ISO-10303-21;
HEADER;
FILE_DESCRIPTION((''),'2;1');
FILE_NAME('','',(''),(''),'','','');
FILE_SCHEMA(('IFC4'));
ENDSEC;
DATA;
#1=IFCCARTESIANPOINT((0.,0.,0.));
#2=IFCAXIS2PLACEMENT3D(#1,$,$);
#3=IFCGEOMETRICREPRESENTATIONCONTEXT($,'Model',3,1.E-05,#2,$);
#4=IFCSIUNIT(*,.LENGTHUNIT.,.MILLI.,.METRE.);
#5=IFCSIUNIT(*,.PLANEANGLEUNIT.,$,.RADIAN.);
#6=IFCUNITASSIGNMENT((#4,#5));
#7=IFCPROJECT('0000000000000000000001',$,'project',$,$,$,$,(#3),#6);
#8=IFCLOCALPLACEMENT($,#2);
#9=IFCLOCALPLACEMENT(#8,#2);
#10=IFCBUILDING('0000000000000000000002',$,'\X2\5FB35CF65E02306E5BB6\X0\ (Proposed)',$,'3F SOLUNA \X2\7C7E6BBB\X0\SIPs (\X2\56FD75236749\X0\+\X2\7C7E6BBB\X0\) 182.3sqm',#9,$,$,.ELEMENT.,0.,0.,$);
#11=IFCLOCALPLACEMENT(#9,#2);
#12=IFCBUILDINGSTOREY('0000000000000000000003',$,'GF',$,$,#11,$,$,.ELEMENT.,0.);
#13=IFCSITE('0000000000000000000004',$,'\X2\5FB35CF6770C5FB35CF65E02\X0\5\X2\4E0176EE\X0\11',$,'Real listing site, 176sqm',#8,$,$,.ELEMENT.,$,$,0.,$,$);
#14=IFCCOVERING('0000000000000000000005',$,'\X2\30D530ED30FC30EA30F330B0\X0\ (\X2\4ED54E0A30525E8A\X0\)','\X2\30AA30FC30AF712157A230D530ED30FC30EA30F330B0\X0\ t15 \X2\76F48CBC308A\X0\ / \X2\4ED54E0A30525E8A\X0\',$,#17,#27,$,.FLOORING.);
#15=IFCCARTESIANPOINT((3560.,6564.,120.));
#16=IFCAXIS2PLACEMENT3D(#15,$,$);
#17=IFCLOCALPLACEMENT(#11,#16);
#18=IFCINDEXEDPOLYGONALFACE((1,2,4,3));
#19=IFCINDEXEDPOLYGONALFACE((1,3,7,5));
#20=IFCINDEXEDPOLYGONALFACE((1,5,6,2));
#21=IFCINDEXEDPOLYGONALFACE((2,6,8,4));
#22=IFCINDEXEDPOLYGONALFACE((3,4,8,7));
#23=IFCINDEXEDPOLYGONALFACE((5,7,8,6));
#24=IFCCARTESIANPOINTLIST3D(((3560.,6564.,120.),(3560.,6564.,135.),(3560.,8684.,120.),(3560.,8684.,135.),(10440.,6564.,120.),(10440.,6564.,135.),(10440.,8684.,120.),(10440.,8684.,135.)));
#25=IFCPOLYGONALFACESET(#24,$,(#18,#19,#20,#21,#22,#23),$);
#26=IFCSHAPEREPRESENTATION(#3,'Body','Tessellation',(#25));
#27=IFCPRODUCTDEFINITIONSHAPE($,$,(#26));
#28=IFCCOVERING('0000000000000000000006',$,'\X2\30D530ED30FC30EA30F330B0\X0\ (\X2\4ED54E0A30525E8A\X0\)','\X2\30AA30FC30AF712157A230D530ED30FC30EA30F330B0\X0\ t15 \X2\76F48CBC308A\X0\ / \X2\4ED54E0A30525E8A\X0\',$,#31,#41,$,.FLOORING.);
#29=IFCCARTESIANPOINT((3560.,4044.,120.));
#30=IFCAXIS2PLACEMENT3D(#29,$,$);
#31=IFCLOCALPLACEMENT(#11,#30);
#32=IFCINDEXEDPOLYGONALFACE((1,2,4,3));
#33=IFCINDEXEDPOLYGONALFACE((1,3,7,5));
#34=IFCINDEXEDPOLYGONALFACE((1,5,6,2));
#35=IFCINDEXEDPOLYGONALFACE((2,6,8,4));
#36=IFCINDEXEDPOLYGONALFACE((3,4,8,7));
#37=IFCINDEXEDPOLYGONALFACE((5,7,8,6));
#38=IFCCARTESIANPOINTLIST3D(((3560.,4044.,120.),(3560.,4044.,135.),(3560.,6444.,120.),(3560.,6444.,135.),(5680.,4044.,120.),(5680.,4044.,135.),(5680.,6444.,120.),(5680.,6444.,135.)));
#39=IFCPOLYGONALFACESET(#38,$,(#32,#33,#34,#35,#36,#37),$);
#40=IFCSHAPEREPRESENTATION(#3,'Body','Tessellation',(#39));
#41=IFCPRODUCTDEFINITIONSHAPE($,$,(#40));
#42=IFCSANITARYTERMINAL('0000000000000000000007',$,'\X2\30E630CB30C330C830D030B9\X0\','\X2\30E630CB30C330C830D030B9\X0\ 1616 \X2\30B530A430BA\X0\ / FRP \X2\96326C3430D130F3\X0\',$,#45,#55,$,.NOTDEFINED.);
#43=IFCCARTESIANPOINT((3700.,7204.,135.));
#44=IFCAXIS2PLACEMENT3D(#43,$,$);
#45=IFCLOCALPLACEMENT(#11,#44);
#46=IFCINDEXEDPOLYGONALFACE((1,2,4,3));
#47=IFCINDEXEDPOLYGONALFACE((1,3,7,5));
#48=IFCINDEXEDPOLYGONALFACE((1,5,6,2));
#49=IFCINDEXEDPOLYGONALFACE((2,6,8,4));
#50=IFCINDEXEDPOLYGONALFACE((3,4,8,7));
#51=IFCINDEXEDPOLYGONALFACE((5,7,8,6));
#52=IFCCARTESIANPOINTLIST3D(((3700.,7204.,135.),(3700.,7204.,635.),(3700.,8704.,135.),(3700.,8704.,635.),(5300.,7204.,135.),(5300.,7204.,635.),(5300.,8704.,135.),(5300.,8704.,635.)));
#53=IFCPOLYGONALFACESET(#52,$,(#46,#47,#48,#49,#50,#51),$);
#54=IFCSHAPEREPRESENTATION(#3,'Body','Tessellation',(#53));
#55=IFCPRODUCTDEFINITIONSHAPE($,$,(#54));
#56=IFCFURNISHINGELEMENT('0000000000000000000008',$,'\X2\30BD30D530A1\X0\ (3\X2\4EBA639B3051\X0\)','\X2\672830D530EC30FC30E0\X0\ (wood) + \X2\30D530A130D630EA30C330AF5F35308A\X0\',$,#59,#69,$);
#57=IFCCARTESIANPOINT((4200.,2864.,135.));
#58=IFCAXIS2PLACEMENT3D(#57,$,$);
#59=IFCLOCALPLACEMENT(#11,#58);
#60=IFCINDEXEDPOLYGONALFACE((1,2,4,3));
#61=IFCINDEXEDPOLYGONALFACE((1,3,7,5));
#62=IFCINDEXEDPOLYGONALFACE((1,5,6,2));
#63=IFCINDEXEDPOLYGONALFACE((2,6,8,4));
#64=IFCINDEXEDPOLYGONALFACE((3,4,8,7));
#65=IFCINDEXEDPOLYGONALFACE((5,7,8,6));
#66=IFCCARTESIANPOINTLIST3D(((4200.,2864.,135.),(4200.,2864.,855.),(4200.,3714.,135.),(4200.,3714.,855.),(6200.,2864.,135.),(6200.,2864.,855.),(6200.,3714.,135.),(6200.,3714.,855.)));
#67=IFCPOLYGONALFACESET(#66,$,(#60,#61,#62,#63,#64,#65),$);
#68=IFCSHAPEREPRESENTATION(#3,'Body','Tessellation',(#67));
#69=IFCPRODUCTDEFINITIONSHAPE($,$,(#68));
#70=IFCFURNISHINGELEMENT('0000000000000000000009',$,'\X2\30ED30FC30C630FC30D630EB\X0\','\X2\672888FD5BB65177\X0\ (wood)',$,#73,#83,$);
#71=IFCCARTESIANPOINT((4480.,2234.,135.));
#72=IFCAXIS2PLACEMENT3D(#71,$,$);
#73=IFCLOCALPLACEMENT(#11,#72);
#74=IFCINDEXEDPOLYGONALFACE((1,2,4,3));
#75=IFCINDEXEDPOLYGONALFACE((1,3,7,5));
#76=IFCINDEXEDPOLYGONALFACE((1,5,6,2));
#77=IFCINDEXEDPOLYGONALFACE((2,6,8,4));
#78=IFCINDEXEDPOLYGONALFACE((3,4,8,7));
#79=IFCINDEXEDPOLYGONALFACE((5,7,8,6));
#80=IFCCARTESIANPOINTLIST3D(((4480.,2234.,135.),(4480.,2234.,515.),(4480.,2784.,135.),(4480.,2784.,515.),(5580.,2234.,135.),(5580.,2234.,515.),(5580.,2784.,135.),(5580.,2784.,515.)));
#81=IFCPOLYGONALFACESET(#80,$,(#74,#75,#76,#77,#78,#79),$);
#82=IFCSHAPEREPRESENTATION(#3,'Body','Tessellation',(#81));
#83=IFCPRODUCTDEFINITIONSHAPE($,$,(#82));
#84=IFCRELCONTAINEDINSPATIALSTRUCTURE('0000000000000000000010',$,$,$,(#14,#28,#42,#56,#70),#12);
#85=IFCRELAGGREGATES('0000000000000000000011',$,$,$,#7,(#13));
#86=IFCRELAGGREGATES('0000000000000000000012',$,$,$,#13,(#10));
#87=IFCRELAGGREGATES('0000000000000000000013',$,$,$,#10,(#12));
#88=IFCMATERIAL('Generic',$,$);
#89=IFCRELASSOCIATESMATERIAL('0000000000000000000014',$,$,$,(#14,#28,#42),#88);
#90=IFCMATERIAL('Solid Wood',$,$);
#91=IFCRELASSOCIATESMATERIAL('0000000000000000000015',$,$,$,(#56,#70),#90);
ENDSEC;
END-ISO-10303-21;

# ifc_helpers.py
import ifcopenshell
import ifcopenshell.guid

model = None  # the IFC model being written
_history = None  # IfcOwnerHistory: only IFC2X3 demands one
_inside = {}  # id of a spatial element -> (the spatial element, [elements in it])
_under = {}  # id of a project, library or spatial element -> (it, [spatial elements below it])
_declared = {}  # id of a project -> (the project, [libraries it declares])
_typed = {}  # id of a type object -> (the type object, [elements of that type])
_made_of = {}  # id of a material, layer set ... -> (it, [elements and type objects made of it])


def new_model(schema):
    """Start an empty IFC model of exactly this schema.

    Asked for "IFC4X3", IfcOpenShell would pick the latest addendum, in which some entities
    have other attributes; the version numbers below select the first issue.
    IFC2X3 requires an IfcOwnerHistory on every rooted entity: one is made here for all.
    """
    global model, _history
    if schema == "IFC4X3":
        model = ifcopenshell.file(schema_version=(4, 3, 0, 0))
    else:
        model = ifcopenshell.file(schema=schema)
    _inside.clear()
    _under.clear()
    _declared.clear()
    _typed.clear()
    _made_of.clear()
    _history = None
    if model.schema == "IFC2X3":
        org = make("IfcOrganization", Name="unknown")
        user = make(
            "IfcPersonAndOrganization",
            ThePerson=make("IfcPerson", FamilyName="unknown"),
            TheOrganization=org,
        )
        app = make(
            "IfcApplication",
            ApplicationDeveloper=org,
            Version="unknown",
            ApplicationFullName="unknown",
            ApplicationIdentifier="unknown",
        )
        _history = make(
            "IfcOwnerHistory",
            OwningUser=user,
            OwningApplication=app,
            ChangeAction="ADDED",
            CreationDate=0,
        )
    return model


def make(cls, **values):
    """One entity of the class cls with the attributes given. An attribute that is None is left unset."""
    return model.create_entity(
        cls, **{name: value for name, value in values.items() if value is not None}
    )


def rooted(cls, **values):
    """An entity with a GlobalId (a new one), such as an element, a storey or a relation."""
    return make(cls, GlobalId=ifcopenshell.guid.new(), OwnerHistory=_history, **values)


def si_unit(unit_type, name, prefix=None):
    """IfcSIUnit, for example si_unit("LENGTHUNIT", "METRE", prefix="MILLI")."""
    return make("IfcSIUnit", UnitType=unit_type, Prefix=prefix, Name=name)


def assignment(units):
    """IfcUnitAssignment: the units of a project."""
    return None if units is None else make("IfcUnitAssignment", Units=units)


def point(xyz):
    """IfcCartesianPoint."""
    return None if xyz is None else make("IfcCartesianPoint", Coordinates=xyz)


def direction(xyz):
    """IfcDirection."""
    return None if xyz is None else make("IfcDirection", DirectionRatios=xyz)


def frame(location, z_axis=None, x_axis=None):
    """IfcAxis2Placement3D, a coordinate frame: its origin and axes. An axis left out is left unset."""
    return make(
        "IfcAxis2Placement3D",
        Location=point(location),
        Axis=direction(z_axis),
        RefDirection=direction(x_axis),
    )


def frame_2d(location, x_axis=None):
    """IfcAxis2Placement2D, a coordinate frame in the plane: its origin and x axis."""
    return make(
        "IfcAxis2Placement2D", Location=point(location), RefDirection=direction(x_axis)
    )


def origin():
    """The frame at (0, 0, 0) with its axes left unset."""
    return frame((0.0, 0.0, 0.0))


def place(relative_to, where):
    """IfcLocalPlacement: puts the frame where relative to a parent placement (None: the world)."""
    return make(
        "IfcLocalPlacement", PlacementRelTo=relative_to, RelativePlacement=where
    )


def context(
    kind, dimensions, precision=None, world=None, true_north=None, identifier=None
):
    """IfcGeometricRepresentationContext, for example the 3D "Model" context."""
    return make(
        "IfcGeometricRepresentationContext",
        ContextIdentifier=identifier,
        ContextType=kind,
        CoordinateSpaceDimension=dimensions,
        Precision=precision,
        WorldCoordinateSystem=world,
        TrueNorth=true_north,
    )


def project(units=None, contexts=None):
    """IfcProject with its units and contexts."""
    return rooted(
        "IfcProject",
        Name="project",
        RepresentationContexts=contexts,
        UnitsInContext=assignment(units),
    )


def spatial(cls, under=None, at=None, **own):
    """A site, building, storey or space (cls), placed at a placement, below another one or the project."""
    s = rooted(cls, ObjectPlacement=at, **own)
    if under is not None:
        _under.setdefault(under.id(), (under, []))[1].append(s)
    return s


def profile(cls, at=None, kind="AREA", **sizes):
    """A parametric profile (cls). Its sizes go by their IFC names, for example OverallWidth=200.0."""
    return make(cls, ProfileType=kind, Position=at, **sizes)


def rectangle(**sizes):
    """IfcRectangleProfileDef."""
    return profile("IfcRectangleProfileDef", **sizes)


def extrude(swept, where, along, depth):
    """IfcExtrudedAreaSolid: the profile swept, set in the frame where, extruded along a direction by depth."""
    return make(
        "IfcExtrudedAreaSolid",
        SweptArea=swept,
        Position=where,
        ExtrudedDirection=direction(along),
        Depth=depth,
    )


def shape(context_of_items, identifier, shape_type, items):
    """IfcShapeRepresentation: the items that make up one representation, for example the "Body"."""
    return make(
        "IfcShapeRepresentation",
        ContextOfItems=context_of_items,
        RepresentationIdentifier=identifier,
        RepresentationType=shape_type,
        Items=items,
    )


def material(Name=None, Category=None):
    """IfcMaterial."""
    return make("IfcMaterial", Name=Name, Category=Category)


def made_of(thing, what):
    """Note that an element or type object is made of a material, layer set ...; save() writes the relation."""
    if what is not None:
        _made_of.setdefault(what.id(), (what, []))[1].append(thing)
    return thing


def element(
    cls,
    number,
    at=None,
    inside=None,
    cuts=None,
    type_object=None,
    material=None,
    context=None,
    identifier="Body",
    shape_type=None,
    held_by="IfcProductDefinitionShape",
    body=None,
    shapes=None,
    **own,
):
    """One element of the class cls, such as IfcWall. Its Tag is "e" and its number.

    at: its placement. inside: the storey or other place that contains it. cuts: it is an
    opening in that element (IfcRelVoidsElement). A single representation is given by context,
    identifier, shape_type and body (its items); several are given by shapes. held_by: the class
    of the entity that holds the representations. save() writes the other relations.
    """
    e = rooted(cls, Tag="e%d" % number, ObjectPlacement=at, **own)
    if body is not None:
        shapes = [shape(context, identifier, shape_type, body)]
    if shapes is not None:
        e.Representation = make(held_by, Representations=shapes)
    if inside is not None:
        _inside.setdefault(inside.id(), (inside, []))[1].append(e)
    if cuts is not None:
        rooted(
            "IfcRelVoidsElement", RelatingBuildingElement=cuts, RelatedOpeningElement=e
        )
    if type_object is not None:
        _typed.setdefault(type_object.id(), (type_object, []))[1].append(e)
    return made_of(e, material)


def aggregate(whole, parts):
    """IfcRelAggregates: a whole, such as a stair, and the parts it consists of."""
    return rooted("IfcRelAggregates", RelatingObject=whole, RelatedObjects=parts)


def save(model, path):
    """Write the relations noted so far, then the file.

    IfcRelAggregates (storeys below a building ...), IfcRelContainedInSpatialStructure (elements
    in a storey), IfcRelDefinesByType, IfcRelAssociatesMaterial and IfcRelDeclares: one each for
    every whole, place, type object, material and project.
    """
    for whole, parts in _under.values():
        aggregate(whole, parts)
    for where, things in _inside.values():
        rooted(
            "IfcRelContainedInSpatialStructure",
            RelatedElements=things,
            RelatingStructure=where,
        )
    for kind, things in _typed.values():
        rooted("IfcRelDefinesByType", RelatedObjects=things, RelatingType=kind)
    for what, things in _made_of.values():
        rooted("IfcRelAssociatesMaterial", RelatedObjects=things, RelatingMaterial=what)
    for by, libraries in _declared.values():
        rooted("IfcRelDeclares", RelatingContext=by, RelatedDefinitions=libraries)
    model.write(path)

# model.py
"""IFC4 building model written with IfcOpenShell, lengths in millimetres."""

from ifc_helpers import new_model, si_unit, frame, frame_2d, origin, place, context, project, spatial, rectangle, extrude, material, element, save


model = new_model("IFC4")

# Units and contexts
model_context = context("Model", 3, precision=1e-05, world=origin())
ifc_project = project(units=[si_unit("LENGTHUNIT", "METRE", prefix="MILLI"), si_unit("PLANEANGLEUNIT", "RADIAN")], contexts=[model_context])

# Site, building, storey
site_placement = place(None, origin())
site = spatial("IfcSite", under=ifc_project, at=site_placement, Name="徳島県徳島市5丁目11", ObjectType="Real listing site, 176sqm", CompositionType="ELEMENT", RefElevation=0.0)
building_placement = place(site_placement, origin())
building = spatial("IfcBuilding", under=site, at=building_placement, Name="徳島市の家 (Proposed)", ObjectType="3F SOLUNA 籾殻SIPs (国産杉+籾殻) 182.3sqm", CompositionType="ELEMENT", ElevationOfRefHeight=0.0, ElevationOfTerrain=0.0)
storey_placement = place(building_placement, origin())
storey = spatial("IfcBuildingStorey", under=building, at=storey_placement, Name="GF", CompositionType="ELEMENT", Elevation=0.0)

# Shared definitions
ifc_material_1 = material(Name="Solid Wood")

# Coverings
ifc_material_2 = material(Name="Generic")
covering_1_placement = place(storey_placement, frame((3560.0, 6564.0, 120.0)))
element("IfcCovering", 1, at=covering_1_placement, inside=storey, material=ifc_material_2, Name="フローリング (仕上げ床)", Description="オーク無垢フローリング t15 直貼り / 仕上げ床", PredefinedType="FLOORING", context=model_context, shape_type="SweptSolid", body=[
    extrude(rectangle(XDim=6880.0, YDim=2120.0, at=frame_2d((3440.0, 1060.0))), frame((3560.0, 6564.0, 120.0)), (0.0, 0.0, 1.0), 15.0),
])
covering_2_placement = place(storey_placement, frame((3560.0, 4044.0, 120.0)))
element("IfcCovering", 2, at=covering_2_placement, inside=storey, material=ifc_material_2, Name="フローリング (仕上げ床)", Description="オーク無垢フローリング t15 直貼り / 仕上げ床", PredefinedType="FLOORING", context=model_context, shape_type="SweptSolid", body=[
    extrude(rectangle(XDim=2120.0, YDim=2400.0, at=frame_2d((1060.0, 1200.0))), frame((3560.0, 4044.0, 120.0)), (0.0, 0.0, 1.0), 15.0),
])

# Sanitary terminal
sanitary_terminal_placement = place(storey_placement, frame((3700.0, 7204.0, 135.0)))
element("IfcSanitaryTerminal", 3, at=sanitary_terminal_placement, inside=storey, material=ifc_material_2, Name="ユニットバス", Description="ユニットバス 1616 サイズ / FRP 防水パン", PredefinedType="NOTDEFINED", context=model_context, shape_type="SweptSolid", body=[
    extrude(rectangle(XDim=1600.0, YDim=1500.0, at=frame_2d((800.0, 750.0))), frame((3700.0, 7204.0, 135.0)), (0.0, 0.0, 1.0), 500.0),
])

# Furnishing elements
furnishing_1_placement = place(storey_placement, frame((4200.0, 2864.0, 135.0)))
element("IfcFurnishingElement", 4, at=furnishing_1_placement, inside=storey, material=ifc_material_1, Name="ソファ (3人掛け)", Description="木フレーム (wood) + ファブリック張り", context=model_context, shape_type="SweptSolid", body=[
    extrude(rectangle(XDim=2000.0, YDim=850.0, at=frame_2d((1000.0, 425.0))), frame((4200.0, 2864.0, 135.0)), (0.0, 0.0, 1.0), 720.0),
])
furnishing_2_placement = place(storey_placement, frame((4480.0, 2234.0, 135.0)))
element("IfcFurnishingElement", 5, at=furnishing_2_placement, inside=storey, material=ifc_material_1, Name="ローテーブル", Description="木製家具 (wood)", context=model_context, shape_type="SweptSolid", body=[
    extrude(rectangle(XDim=1100.0, YDim=550.0, at=frame_2d((550.0, 275.0))), frame((4480.0, 2234.0, 135.0)), (0.0, 0.0, 1.0), 380.0),
])

save(model, "model.ifc")
